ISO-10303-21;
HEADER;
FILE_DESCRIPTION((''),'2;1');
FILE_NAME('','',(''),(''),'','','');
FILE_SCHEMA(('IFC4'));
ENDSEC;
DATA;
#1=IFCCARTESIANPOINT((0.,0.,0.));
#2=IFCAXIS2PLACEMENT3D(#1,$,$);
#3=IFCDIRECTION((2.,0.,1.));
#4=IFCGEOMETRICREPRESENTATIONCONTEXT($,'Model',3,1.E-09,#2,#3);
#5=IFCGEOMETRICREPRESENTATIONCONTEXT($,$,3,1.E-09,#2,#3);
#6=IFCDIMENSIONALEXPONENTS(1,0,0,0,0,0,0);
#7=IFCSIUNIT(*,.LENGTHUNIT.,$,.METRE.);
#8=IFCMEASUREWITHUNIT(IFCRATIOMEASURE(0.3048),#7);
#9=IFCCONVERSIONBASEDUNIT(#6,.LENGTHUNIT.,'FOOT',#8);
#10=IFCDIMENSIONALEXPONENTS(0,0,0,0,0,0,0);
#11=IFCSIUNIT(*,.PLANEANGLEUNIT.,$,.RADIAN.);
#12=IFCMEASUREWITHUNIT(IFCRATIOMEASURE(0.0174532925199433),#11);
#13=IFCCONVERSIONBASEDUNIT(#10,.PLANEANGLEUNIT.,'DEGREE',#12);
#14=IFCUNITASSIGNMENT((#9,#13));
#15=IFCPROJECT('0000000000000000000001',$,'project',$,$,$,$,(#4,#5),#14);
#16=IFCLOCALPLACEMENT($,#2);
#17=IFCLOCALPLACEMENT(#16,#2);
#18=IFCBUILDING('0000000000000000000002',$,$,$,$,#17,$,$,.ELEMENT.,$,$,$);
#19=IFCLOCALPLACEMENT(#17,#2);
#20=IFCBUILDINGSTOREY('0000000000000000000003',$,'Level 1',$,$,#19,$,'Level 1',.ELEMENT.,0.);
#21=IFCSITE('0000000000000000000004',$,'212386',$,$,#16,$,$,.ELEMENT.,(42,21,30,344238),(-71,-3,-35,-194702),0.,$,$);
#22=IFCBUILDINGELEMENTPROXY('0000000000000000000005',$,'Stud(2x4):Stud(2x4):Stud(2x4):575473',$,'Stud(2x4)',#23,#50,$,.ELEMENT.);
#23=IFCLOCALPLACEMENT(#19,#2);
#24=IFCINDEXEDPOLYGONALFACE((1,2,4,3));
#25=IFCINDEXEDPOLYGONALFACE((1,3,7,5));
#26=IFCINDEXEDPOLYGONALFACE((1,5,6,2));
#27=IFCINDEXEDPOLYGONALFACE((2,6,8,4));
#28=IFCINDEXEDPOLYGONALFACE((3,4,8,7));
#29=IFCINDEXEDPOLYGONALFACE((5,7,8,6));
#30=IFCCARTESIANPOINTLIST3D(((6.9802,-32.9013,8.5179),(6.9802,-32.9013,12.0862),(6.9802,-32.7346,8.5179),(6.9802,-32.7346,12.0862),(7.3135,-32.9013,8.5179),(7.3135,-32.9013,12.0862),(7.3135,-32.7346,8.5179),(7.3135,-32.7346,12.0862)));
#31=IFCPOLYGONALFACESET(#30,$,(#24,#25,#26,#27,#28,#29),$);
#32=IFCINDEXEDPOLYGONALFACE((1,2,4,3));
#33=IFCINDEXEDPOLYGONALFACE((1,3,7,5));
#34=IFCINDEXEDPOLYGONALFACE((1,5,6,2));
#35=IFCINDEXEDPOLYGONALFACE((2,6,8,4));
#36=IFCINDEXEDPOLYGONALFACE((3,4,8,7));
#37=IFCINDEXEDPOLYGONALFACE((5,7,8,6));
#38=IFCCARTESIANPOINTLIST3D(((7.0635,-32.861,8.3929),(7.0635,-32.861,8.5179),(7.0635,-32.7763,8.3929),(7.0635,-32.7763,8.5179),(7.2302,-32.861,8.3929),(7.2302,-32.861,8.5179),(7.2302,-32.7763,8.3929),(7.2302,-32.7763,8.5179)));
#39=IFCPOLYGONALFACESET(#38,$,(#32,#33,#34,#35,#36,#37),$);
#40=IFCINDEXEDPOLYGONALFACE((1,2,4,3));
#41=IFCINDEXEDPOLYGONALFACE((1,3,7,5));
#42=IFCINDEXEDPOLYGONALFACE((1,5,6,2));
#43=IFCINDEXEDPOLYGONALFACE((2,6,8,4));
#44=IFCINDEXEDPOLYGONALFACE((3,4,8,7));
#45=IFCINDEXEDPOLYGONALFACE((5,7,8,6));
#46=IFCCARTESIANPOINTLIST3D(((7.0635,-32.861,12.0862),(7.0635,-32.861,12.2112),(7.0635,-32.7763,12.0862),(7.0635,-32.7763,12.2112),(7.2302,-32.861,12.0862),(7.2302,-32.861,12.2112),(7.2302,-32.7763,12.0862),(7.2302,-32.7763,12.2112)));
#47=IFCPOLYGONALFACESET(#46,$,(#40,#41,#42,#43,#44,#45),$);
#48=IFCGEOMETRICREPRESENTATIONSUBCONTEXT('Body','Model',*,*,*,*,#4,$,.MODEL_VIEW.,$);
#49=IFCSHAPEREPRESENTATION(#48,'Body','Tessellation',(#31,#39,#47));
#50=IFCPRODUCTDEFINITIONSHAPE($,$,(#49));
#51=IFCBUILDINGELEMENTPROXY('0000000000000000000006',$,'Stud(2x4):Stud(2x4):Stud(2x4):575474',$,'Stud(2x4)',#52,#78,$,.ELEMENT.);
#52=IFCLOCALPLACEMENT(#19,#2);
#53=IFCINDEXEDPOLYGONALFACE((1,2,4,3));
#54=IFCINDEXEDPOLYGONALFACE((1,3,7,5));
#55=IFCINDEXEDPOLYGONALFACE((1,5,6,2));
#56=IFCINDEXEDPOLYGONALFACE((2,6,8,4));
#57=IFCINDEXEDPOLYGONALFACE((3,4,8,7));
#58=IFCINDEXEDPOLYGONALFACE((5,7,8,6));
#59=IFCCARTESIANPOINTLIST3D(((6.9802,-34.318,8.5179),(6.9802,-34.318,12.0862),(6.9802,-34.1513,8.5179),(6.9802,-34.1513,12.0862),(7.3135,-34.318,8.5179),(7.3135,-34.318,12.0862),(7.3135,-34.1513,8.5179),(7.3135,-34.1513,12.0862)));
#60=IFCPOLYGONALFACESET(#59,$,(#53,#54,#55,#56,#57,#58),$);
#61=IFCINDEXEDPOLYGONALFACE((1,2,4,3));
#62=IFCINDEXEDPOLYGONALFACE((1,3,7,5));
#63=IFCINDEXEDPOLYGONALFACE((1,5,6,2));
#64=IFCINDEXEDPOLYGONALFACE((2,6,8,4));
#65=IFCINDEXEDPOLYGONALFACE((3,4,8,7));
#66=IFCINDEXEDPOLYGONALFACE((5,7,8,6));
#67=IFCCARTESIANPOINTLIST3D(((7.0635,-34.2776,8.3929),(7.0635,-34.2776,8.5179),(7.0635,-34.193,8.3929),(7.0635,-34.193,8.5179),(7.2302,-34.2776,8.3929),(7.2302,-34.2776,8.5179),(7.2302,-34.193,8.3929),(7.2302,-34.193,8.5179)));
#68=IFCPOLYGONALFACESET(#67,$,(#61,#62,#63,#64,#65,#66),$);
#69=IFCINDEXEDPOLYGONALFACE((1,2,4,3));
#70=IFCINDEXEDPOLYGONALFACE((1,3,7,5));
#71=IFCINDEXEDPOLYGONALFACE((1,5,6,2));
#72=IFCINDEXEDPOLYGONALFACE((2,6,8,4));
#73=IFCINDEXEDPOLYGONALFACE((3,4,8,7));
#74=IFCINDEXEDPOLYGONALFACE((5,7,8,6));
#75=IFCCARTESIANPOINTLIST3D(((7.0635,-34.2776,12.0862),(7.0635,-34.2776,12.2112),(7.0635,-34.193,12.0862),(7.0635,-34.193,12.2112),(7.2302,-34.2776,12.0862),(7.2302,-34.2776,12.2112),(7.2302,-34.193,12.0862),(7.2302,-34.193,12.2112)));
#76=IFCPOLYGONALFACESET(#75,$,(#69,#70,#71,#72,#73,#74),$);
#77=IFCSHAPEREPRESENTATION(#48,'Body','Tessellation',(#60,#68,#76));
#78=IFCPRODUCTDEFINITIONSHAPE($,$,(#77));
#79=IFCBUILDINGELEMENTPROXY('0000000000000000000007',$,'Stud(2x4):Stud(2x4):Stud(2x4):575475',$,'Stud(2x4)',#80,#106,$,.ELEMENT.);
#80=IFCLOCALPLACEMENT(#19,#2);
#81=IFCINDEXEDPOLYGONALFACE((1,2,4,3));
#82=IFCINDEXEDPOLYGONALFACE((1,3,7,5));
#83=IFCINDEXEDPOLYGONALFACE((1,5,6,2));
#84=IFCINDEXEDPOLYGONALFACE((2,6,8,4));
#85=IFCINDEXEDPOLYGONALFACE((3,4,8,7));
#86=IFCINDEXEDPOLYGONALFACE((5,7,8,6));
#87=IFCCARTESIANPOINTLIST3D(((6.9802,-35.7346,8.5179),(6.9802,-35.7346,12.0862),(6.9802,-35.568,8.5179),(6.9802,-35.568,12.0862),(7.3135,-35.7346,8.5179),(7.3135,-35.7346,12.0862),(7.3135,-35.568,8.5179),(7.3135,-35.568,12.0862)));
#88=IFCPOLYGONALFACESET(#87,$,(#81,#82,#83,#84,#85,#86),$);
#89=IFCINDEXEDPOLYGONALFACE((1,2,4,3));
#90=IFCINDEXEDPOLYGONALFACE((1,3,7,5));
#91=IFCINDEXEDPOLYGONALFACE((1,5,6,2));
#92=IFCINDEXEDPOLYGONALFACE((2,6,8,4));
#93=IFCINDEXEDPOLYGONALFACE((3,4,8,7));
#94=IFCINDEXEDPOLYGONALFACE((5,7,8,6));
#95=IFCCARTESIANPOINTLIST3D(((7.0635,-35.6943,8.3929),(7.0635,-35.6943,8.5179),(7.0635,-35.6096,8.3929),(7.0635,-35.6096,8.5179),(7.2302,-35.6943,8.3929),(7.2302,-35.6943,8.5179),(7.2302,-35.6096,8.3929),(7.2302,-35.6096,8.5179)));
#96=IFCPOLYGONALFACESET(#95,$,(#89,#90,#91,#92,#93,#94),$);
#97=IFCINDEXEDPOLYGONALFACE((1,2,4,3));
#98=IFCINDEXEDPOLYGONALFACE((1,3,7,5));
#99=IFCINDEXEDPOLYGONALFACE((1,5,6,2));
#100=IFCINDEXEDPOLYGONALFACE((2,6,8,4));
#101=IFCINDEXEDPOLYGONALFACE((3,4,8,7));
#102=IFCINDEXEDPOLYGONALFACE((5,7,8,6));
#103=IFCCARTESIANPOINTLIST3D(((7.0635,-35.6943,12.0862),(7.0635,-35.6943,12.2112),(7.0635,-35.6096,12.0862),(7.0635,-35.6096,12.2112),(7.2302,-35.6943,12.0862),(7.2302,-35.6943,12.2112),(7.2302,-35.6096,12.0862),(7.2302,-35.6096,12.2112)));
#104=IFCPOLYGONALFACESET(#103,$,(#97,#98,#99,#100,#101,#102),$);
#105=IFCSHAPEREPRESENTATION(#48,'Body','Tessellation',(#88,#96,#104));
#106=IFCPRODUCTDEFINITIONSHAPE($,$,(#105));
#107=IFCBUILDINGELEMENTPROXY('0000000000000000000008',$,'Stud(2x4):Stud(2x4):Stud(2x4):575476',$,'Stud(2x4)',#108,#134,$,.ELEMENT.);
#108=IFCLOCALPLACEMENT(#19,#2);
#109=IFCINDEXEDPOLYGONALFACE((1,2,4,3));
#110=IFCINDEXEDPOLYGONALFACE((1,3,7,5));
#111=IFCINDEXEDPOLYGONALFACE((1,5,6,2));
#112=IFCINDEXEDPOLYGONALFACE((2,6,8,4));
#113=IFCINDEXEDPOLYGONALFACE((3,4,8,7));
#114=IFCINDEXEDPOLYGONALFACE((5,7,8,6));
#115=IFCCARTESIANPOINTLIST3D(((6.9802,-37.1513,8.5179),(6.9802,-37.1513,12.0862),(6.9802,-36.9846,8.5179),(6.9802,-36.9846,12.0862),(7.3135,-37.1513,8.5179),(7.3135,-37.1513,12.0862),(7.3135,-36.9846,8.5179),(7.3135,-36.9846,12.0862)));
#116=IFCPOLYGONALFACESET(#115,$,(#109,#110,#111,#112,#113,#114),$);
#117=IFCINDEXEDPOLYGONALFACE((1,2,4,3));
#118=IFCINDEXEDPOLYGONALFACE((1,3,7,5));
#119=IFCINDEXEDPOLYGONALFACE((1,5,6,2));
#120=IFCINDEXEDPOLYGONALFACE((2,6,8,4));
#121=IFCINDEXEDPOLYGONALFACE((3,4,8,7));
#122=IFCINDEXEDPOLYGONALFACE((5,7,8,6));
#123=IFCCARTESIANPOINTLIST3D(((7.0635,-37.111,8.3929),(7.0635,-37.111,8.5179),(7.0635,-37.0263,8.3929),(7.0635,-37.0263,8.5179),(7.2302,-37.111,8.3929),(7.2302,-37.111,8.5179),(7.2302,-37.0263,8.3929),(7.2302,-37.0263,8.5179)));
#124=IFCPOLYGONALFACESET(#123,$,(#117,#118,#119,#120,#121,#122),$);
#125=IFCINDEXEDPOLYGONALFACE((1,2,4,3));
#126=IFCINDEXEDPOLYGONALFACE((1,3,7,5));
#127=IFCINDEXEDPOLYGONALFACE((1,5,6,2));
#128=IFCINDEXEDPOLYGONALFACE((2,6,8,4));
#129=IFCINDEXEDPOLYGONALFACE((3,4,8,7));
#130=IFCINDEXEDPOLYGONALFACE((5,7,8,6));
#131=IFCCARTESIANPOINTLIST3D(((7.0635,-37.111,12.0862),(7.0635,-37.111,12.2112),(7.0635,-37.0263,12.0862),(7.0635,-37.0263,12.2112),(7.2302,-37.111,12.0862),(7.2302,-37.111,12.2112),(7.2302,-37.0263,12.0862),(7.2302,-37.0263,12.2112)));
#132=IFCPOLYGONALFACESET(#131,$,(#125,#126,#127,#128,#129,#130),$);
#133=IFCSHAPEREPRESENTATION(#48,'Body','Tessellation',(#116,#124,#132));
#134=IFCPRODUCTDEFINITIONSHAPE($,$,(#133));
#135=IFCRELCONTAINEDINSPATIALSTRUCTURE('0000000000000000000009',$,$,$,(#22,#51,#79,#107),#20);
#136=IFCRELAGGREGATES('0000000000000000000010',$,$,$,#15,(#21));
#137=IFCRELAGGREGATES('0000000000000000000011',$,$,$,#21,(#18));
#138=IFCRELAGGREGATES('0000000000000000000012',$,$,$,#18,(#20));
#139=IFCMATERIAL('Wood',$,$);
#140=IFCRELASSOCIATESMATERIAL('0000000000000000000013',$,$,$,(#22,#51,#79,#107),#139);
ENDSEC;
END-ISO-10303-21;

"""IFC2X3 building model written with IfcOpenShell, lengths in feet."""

from ifc_helpers import new_model, entity, si_unit, converted_unit, direction, frame, frame_2d, origin, place, context, subcontext, project, spatial, rectangle, extrude, source, transform, mapped, material, element, save


model = new_model("IFC2X3")

# Units and contexts
model_context = context("Model", 3, precision=1e-09, world=origin(), true_north=direction((2.0, 0.0, 1.0)))
context_of_model = context(None, 3, precision=1e-09, world=origin(), true_north=direction((2.0, 0.0, 1.0)))
body_context = subcontext(model_context, "Body", "Model", "MODEL_VIEW")
ifc_project = project(units=[converted_unit("LENGTHUNIT", "FOOT", entity("IfcRatioMeasure", 0.3048), si_unit("LENGTHUNIT", "METRE"), dimensions=[1, 0, 0, 0, 0, 0, 0]), converted_unit("PLANEANGLEUNIT", "DEGREE", entity("IfcRatioMeasure", 0.0174532925199433), si_unit("PLANEANGLEUNIT", "RADIAN"), dimensions=[0, 0, 0, 0, 0, 0, 0])], contexts=[model_context, context_of_model])

# Site, building, storey
site_placement = place(None, origin())
site = spatial("IfcSite", under=ifc_project, at=site_placement, Name="212386", CompositionType="ELEMENT", RefLatitude=(42, 21, 30, 344238), RefLongitude=(-71, -3, -35, -194702), RefElevation=0.0)
building_placement = place(site_placement, origin())
building = spatial("IfcBuilding", under=site, at=building_placement, CompositionType="ELEMENT")
storey_placement = place(building_placement, origin())
storey = spatial("IfcBuildingStorey", under=building, at=storey_placement, Name="Level 1", LongName="Level 1", CompositionType="ELEMENT", Elevation=0.0)

# Building element proxies
ifc_material = material(Name="Wood")
shared_shape_1 = source(origin(), body_context, "Body", "SweptSolid", [
    extrude(rectangle(XDim=0.3333, YDim=0.1667, at=frame_2d((0.0, 0.0), x_axis=(1.0, 0.0))), frame((7.1469, -32.818, 8.5179), z_axis=(0.0, 0.0, 1.0), x_axis=(-1.0, 0.0, 0.0)), (0.0, 0.0, 1.0), 3.5684),
    extrude(rectangle(XDim=0.1667, YDim=0.0847, at=frame_2d((0.0, 0.0), x_axis=(1.0, 0.0))), frame((7.1469, -32.8186, 8.3929), z_axis=(0.0, 0.0, 1.0), x_axis=(-1.0, 0.0, 0.0)), (0.0, 0.0, 1.0), 0.125),
    extrude(rectangle(XDim=0.0847, YDim=0.1667, at=frame_2d((0.0, 0.0), x_axis=(1.0, 0.0))), frame((7.1469, -32.8186, 12.0862), z_axis=(0.0, 0.0, 1.0), x_axis=(0.0, -1.0, 0.0)), (0.0, 0.0, 1.0), 0.125),
])
proxy_1_placement = place(storey_placement, origin())
element("IfcBuildingElementProxy", 1, at=proxy_1_placement, inside=storey, material=ifc_material, Name="Stud(2x4):Stud(2x4):Stud(2x4):575473", ObjectType="Stud(2x4)", CompositionType="ELEMENT", context=body_context, shape_type="MappedRepresentation", body=[
    mapped(shared_shape_1, transform((0.0, 0.0, 0.0), scale=1.0)),
])
shared_shape_2 = source(origin(), body_context, "Body", "SweptSolid", [
    extrude(rectangle(XDim=0.3333, YDim=0.1667, at=frame_2d((0.0, 0.0), x_axis=(1.0, 0.0))), frame((7.1469, -34.2346, 8.5179), z_axis=(0.0, 0.0, 1.0), x_axis=(-1.0, 0.0, 0.0)), (0.0, 0.0, 1.0), 3.5684),
    extrude(rectangle(XDim=0.1667, YDim=0.0847, at=frame_2d((0.0, 0.0), x_axis=(1.0, 0.0))), frame((7.1469, -34.2353, 8.3929), z_axis=(0.0, 0.0, 1.0), x_axis=(-1.0, 0.0, 0.0)), (0.0, 0.0, 1.0), 0.125),
    extrude(rectangle(XDim=0.0847, YDim=0.1667, at=frame_2d((0.0, 0.0), x_axis=(1.0, 0.0))), frame((7.1469, -34.2353, 12.0862), z_axis=(0.0, 0.0, 1.0), x_axis=(0.0, -1.0, 0.0)), (0.0, 0.0, 1.0), 0.125),
])
proxy_2_placement = place(storey_placement, origin())
element("IfcBuildingElementProxy", 2, at=proxy_2_placement, inside=storey, material=ifc_material, Name="Stud(2x4):Stud(2x4):Stud(2x4):575474", ObjectType="Stud(2x4)", CompositionType="ELEMENT", context=body_context, shape_type="MappedRepresentation", body=[
    mapped(shared_shape_2, transform((0.0, 0.0, 0.0), scale=1.0)),
])
shared_shape_3 = source(origin(), body_context, "Body", "SweptSolid", [
    extrude(rectangle(XDim=0.3333, YDim=0.1667, at=frame_2d((0.0, 0.0), x_axis=(1.0, 0.0))), frame((7.1469, -35.6513, 8.5179), z_axis=(0.0, 0.0, 1.0), x_axis=(-1.0, 0.0, 0.0)), (0.0, 0.0, 1.0), 3.5684),
    extrude(rectangle(XDim=0.1667, YDim=0.0847, at=frame_2d((0.0, 0.0), x_axis=(1.0, 0.0))), frame((7.1469, -35.652, 8.3929), z_axis=(0.0, 0.0, 1.0), x_axis=(-1.0, 0.0, 0.0)), (0.0, 0.0, 1.0), 0.125),
    extrude(rectangle(XDim=0.0847, YDim=0.1667, at=frame_2d((0.0, 0.0), x_axis=(1.0, 0.0))), frame((7.1469, -35.652, 12.0862), z_axis=(0.0, 0.0, 1.0), x_axis=(0.0, -1.0, 0.0)), (0.0, 0.0, 1.0), 0.125),
])
proxy_3_placement = place(storey_placement, origin())
element("IfcBuildingElementProxy", 3, at=proxy_3_placement, inside=storey, material=ifc_material, Name="Stud(2x4):Stud(2x4):Stud(2x4):575475", ObjectType="Stud(2x4)", CompositionType="ELEMENT", context=body_context, shape_type="MappedRepresentation", body=[
    mapped(shared_shape_3, transform((0.0, 0.0, 0.0), scale=1.0)),
])
shared_shape_4 = source(origin(), body_context, "Body", "SweptSolid", [
    extrude(rectangle(XDim=0.3333, YDim=0.1667, at=frame_2d((0.0, 0.0), x_axis=(1.0, 0.0))), frame((7.1469, -37.068, 8.5179), z_axis=(0.0, 0.0, 1.0), x_axis=(-1.0, 0.0, 0.0)), (0.0, 0.0, 1.0), 3.5684),
    extrude(rectangle(XDim=0.1667, YDim=0.0847, at=frame_2d((0.0, 0.0), x_axis=(1.0, 0.0))), frame((7.1469, -37.0686, 8.3929), z_axis=(0.0, 0.0, 1.0), x_axis=(-1.0, 0.0, 0.0)), (0.0, 0.0, 1.0), 0.125),
    extrude(rectangle(XDim=0.0847, YDim=0.1667, at=frame_2d((0.0, 0.0), x_axis=(1.0, 0.0))), frame((7.1469, -37.0686, 12.0862), z_axis=(0.0, 0.0, 1.0), x_axis=(0.0, -1.0, 0.0)), (0.0, 0.0, 1.0), 0.125),
])
proxy_4_placement = place(storey_placement, origin())
element("IfcBuildingElementProxy", 4, at=proxy_4_placement, inside=storey, material=ifc_material, Name="Stud(2x4):Stud(2x4):Stud(2x4):575476", ObjectType="Stud(2x4)", CompositionType="ELEMENT", context=body_context, shape_type="MappedRepresentation", body=[
    mapped(shared_shape_4, transform((0.0, 0.0, 0.0), scale=1.0)),
])

save(model, "model.ifc")
